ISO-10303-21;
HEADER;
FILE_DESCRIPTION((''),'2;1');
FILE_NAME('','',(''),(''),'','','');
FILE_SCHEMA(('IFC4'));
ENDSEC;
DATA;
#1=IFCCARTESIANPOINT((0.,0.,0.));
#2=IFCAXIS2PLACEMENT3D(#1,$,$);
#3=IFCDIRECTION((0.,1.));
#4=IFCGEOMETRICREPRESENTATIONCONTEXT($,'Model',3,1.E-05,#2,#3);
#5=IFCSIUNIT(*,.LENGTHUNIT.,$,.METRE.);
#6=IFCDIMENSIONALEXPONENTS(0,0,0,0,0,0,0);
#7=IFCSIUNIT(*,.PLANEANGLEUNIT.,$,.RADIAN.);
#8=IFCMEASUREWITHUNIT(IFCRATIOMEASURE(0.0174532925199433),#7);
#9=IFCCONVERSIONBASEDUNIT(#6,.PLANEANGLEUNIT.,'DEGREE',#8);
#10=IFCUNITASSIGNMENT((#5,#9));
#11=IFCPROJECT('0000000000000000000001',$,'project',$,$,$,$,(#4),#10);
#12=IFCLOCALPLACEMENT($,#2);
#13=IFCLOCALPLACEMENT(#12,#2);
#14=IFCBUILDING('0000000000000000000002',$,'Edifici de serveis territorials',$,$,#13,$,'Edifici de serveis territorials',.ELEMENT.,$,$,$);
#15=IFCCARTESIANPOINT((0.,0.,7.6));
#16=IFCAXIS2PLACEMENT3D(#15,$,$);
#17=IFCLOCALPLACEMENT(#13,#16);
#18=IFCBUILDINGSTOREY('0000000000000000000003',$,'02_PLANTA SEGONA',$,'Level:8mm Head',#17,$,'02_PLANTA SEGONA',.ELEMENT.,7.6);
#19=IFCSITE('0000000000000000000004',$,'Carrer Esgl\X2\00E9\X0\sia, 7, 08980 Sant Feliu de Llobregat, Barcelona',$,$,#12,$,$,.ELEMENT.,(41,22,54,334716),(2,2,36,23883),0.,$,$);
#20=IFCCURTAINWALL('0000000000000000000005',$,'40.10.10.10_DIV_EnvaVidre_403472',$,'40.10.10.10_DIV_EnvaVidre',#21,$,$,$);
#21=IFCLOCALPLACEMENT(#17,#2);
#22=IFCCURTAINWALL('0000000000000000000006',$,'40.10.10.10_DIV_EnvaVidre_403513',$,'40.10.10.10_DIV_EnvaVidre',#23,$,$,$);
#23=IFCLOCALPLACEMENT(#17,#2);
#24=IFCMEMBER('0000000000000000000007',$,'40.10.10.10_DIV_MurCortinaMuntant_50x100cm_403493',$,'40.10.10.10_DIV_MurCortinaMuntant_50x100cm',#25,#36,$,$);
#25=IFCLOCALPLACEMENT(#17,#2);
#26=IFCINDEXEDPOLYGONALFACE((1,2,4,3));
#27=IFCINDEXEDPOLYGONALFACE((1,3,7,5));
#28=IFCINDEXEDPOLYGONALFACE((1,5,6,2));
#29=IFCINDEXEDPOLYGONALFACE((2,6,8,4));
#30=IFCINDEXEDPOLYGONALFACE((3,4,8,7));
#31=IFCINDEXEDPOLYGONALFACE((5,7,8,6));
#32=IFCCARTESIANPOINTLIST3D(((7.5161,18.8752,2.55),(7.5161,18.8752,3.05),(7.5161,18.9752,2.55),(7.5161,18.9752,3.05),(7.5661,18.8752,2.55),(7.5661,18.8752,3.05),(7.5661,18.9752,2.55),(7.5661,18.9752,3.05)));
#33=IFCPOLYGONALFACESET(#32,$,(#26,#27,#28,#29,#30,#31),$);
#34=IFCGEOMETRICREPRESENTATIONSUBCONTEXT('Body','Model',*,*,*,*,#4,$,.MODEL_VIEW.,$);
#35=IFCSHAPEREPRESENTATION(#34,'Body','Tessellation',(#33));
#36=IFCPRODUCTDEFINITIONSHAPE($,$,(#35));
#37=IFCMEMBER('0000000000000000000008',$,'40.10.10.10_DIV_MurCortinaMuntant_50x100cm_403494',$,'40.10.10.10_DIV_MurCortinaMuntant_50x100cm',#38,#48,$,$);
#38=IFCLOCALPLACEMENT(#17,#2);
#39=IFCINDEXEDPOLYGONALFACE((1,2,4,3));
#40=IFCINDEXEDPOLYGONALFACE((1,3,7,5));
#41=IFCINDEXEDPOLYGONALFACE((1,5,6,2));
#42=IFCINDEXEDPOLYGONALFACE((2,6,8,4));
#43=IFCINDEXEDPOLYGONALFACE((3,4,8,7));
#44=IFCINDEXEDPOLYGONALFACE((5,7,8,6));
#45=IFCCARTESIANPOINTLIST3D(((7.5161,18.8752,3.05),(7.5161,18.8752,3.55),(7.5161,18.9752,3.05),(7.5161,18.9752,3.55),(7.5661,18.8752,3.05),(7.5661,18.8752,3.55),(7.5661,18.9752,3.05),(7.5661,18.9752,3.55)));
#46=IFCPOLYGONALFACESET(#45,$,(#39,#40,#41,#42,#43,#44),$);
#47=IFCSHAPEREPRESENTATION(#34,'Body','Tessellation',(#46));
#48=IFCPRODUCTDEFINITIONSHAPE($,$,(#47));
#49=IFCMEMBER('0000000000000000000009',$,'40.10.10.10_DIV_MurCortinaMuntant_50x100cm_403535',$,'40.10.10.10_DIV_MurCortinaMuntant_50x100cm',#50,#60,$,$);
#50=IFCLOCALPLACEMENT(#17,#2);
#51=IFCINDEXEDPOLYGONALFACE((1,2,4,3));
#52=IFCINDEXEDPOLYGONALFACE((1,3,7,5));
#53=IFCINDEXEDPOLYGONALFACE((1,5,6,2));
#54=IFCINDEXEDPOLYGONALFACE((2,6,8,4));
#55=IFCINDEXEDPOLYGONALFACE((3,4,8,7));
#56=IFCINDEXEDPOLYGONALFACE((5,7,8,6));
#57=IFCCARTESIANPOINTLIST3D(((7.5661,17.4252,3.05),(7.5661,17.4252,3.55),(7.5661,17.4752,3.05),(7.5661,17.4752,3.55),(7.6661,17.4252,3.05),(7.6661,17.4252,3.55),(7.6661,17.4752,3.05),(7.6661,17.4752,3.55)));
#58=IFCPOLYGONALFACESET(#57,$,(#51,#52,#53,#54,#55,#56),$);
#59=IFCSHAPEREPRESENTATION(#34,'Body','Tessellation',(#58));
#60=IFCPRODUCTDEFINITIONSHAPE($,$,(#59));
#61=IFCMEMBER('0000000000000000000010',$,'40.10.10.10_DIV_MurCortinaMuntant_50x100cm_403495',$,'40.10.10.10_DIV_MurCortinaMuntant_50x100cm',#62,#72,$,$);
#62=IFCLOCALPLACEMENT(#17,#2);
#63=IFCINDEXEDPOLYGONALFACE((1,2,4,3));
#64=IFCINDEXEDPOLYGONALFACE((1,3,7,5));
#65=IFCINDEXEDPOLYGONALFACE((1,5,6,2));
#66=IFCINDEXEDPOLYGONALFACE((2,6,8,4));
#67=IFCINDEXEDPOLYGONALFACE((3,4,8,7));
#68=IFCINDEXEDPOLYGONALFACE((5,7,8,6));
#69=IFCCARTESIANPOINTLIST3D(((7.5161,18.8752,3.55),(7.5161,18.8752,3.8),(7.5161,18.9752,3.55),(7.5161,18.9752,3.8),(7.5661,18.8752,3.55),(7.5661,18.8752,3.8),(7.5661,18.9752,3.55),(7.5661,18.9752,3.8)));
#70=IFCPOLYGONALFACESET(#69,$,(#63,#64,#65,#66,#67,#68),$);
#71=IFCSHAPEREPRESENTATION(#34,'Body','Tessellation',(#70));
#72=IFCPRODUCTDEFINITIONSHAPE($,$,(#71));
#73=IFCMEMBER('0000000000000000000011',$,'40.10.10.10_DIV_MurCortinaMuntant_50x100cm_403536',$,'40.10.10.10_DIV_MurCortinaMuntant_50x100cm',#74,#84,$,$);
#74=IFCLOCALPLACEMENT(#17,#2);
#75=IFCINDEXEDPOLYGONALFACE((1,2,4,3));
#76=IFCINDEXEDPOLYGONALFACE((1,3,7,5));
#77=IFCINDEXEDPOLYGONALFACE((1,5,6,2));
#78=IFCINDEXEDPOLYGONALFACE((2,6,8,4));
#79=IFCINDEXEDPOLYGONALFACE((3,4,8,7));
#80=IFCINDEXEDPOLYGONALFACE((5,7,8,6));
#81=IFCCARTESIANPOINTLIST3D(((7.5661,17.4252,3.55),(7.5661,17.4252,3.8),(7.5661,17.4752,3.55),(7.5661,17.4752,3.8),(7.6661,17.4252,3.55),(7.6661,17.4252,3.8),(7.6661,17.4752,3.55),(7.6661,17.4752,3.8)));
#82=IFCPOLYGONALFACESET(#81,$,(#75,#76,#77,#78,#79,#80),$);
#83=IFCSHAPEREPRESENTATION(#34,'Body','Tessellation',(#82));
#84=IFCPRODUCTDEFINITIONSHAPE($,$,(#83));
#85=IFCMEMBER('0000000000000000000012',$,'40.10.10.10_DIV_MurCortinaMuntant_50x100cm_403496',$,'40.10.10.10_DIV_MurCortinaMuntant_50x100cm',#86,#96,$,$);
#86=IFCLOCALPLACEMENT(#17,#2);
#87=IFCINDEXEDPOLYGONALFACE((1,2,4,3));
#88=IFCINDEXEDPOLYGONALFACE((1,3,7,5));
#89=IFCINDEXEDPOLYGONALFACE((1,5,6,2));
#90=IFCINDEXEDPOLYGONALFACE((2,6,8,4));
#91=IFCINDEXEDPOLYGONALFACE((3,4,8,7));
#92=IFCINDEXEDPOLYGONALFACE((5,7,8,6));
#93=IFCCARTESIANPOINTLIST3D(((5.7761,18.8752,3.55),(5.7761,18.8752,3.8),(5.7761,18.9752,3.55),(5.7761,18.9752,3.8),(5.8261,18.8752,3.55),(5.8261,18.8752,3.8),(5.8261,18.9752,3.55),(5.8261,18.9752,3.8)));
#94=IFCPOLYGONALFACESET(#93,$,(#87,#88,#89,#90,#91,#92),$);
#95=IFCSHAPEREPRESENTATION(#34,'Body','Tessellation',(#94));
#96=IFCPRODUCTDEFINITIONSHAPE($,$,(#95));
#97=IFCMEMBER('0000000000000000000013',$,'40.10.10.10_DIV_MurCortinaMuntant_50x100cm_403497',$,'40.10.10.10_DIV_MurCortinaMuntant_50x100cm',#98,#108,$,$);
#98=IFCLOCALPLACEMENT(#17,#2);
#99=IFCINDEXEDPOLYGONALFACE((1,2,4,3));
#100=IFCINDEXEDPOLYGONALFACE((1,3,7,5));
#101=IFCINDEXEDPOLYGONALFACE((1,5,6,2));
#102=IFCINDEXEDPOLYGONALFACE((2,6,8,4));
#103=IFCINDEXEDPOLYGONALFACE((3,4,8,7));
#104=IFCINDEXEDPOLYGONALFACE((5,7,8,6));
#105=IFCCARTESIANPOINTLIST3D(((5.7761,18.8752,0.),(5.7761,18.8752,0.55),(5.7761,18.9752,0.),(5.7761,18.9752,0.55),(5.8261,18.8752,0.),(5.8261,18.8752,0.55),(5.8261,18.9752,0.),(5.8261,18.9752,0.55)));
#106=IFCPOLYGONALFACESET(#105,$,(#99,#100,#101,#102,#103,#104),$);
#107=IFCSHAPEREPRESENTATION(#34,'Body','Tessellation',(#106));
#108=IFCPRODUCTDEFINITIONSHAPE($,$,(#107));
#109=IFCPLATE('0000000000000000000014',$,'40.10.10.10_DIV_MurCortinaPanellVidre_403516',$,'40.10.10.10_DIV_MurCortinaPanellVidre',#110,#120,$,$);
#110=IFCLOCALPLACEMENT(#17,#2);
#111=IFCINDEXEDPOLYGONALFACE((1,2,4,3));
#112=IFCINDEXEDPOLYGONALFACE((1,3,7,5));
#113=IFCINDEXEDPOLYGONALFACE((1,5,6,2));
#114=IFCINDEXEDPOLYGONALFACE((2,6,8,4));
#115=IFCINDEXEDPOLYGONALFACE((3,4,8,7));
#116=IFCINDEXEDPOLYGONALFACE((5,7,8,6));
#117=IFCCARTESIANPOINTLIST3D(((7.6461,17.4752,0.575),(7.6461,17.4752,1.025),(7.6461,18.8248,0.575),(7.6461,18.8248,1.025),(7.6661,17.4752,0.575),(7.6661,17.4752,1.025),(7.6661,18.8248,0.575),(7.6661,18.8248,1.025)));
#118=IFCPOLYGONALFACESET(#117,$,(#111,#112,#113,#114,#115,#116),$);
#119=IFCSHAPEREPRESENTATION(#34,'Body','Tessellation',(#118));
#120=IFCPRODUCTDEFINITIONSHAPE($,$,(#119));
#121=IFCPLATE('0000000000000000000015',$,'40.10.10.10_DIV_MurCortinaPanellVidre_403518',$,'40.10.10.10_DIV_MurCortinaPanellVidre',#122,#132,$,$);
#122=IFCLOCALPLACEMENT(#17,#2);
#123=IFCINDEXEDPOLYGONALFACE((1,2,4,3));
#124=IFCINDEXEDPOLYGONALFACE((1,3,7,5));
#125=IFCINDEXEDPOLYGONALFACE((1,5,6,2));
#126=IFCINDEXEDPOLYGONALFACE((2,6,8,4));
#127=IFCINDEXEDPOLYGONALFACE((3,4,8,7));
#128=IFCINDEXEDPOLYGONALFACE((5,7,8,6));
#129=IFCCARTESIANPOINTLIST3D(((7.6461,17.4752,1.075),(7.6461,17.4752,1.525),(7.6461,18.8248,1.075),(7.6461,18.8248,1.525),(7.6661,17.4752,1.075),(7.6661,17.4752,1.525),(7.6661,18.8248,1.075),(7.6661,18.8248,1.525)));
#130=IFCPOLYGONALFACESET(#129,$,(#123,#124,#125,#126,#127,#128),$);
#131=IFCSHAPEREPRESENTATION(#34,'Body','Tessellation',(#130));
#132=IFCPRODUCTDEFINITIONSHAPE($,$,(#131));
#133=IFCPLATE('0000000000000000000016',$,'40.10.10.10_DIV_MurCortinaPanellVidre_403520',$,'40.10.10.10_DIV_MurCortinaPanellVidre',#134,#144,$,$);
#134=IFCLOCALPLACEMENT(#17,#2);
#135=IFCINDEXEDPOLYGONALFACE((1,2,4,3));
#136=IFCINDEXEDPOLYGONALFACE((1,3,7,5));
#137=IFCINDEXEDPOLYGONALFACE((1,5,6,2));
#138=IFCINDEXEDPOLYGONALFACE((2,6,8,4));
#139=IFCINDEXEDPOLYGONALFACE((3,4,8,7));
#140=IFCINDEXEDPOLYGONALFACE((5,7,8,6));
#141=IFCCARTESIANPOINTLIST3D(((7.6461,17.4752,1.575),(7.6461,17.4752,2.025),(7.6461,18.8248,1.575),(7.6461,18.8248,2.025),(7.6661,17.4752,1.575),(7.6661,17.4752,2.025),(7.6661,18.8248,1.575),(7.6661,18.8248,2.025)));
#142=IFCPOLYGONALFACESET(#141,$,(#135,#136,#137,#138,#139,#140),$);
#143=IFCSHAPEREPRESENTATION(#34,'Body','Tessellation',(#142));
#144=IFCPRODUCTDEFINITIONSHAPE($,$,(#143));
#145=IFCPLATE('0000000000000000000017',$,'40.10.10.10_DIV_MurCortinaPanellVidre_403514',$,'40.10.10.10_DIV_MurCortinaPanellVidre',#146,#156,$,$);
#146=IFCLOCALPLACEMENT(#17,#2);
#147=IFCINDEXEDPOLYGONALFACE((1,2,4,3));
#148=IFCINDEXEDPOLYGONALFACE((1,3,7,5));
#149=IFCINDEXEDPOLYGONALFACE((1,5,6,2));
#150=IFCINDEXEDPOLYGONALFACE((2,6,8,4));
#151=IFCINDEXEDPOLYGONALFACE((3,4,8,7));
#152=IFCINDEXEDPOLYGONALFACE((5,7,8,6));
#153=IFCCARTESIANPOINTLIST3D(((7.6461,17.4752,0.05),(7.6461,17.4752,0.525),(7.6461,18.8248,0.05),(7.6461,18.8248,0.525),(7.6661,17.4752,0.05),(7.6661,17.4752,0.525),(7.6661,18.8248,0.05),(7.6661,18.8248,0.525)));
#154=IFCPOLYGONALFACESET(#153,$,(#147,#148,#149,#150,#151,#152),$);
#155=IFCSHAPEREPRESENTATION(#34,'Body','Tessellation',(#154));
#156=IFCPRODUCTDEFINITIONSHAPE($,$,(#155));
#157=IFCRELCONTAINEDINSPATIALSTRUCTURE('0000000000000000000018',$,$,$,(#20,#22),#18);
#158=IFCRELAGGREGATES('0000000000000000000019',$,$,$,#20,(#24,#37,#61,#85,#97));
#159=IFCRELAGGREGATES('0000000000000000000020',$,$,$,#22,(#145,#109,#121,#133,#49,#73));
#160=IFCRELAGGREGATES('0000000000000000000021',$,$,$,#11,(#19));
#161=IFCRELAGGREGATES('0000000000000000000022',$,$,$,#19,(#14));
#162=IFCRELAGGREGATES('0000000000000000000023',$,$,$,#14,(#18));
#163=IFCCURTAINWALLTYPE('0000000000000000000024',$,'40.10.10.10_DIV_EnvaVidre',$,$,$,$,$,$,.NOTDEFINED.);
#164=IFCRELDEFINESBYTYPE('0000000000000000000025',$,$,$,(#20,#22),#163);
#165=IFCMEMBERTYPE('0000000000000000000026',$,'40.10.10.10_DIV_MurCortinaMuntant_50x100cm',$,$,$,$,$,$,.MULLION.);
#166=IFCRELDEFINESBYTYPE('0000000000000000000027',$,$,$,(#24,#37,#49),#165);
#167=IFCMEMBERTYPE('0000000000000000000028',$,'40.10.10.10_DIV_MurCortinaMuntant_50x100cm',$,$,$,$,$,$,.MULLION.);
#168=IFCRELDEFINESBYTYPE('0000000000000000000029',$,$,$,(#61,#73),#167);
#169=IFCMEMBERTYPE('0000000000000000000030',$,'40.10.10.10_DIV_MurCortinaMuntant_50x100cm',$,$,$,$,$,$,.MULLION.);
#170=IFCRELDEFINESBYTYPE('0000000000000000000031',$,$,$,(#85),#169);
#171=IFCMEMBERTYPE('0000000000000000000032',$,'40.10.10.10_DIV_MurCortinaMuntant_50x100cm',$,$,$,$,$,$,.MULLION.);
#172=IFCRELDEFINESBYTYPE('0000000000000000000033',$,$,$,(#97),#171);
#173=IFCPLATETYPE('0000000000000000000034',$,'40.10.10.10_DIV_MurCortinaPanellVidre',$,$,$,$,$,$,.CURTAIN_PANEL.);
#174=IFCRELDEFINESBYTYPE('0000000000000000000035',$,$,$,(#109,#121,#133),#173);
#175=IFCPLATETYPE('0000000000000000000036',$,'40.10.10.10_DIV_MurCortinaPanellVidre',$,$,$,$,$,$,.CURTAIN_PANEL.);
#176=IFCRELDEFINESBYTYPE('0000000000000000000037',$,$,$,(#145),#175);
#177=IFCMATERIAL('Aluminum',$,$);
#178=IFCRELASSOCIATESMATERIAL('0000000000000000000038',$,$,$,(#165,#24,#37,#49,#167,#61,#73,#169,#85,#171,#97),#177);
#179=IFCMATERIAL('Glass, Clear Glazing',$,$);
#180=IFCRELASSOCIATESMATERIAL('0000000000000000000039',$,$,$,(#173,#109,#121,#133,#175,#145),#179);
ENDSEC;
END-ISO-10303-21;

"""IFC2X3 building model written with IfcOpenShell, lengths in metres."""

from ifc_helpers import new_model, entity, si_unit, converted_unit, direction, frame, frame_2d, origin, origin_2d_with_axis, place, context, subcontext, project, spatial, rectangle, extrude, source, transform, mapped, material, type_object, type_shapes, element, aggregate, save


model = new_model("IFC2X3")

# Units and contexts
model_context = context("Model", 3, precision=1e-05, world=origin(), true_north=direction((0.0, 1.0)))
body_context = subcontext(model_context, "Body", "Model", "MODEL_VIEW")
ifc_project = project(units=[si_unit("LENGTHUNIT", "METRE"), converted_unit("PLANEANGLEUNIT", "DEGREE", entity("IfcRatioMeasure", 0.0174532925199433), si_unit("PLANEANGLEUNIT", "RADIAN"), dimensions=[0, 0, 0, 0, 0, 0, 0])], contexts=[model_context])

# Site, building, storey
site_placement = place(None, origin())
site = spatial("IfcSite", under=ifc_project, at=site_placement, Name="Carrer Església, 7, 08980 Sant Feliu de Llobregat, Barcelona", CompositionType="ELEMENT", RefLatitude=(41, 22, 54, 334716), RefLongitude=(2, 2, 36, 23883), RefElevation=0.0)
building_placement = place(site_placement, origin())
building = spatial("IfcBuilding", under=site, at=building_placement, Name="Edifici de serveis territorials", LongName="Edifici de serveis territorials", CompositionType="ELEMENT")
storey_placement = place(building_placement, frame((0.0, 0.0, 7.6)))
storey = spatial("IfcBuildingStorey", under=building, at=storey_placement, Name="02_PLANTA SEGONA", ObjectType="Level:8mm Head", LongName="02_PLANTA SEGONA", CompositionType="ELEMENT", Elevation=7.6)

# Curtain walls
curtain_wall_type = type_object("IfcCurtainWallType", Name="40.10.10.10_DIV_EnvaVidre", PredefinedType="NOTDEFINED")
curtain_wall_1_placement = place(storey_placement, frame((0.0, 0.0, -7.6)))
curtain_wall_1 = element("IfcCurtainWall", 1, at=curtain_wall_1_placement, inside=storey, type_object=curtain_wall_type, Name="40.10.10.10_DIV_EnvaVidre_403472", ObjectType="40.10.10.10_DIV_EnvaVidre")
ifc_material_1 = material(Name="Aluminum")
curtain_wall_2_placement = place(storey_placement, frame((0.0, 0.0, -7.6)))
curtain_wall_2 = element("IfcCurtainWall", 2, at=curtain_wall_2_placement, inside=storey, type_object=curtain_wall_type, Name="40.10.10.10_DIV_EnvaVidre_403513", ObjectType="40.10.10.10_DIV_EnvaVidre")

# Members
member_type_1 = type_object("IfcMemberType", Name="40.10.10.10_DIV_MurCortinaMuntant_50x100cm", PredefinedType="MULLION", material=ifc_material_1)
shared_shape_1 = source(origin(), body_context, "Body", "SweptSolid", [
    extrude(rectangle(XDim=0.1, YDim=0.05, at=origin_2d_with_axis()), frame((-0.025, 0.0, -0.5), z_axis=(0.0, 0.0, 1.0), x_axis=(0.0, -1.0, 0.0)), (0.0, 0.0, 1.0), 0.5),
])
type_shapes(member_type_1, [shared_shape_1])
member_1_placement = place(storey_placement, frame((7.5661, 18.9252, 2.55), z_axis=(0.0, 0.0, -1.0), x_axis=(1.0, 0.0, 0.0)))
member_1 = element("IfcMember", 3, at=member_1_placement, type_object=member_type_1, material=ifc_material_1, Name="40.10.10.10_DIV_MurCortinaMuntant_50x100cm_403493", ObjectType="40.10.10.10_DIV_MurCortinaMuntant_50x100cm", context=body_context, shape_type="MappedRepresentation", body=[
    mapped(shared_shape_1, transform((0.0, 0.0, 0.0), scale=1.0)),
])
member_2_placement = place(storey_placement, frame((7.5661, 18.9252, 3.05), z_axis=(0.0, 0.0, -1.0), x_axis=(1.0, 0.0, 0.0)))
member_2 = element("IfcMember", 4, at=member_2_placement, type_object=member_type_1, material=ifc_material_1, Name="40.10.10.10_DIV_MurCortinaMuntant_50x100cm_403494", ObjectType="40.10.10.10_DIV_MurCortinaMuntant_50x100cm", context=body_context, shape_type="MappedRepresentation", body=[
    mapped(shared_shape_1, transform((0.0, 0.0, 0.0), scale=1.0)),
])
member_3_placement = place(storey_placement, frame((7.6161, 17.4252, 3.05), z_axis=(0.0, 0.0, -1.0), x_axis=(0.0, -1.0, 0.0)))
member_3 = element("IfcMember", 5, at=member_3_placement, type_object=member_type_1, material=ifc_material_1, Name="40.10.10.10_DIV_MurCortinaMuntant_50x100cm_403535", ObjectType="40.10.10.10_DIV_MurCortinaMuntant_50x100cm", context=body_context, shape_type="MappedRepresentation", body=[
    mapped(shared_shape_1, transform((0.0, 0.0, 0.0), scale=1.0)),
])
member_type_2 = type_object("IfcMemberType", Name="40.10.10.10_DIV_MurCortinaMuntant_50x100cm", PredefinedType="MULLION", material=ifc_material_1)
shared_shape_2 = source(origin(), body_context, "Body", "SweptSolid", [
    extrude(rectangle(XDim=0.1, YDim=0.05, at=origin_2d_with_axis()), frame((-0.025, 0.0, -0.25), z_axis=(0.0, 0.0, 1.0), x_axis=(0.0, -1.0, 0.0)), (0.0, 0.0, 1.0), 0.25),
])
type_shapes(member_type_2, [shared_shape_2])
member_4_placement = place(storey_placement, frame((7.5661, 18.9252, 3.55), z_axis=(0.0, 0.0, -1.0), x_axis=(1.0, 0.0, 0.0)))
member_4 = element("IfcMember", 6, at=member_4_placement, type_object=member_type_2, material=ifc_material_1, Name="40.10.10.10_DIV_MurCortinaMuntant_50x100cm_403495", ObjectType="40.10.10.10_DIV_MurCortinaMuntant_50x100cm", context=body_context, shape_type="MappedRepresentation", body=[
    mapped(shared_shape_2, transform((0.0, 0.0, 0.0), scale=1.0)),
])
member_5_placement = place(storey_placement, frame((7.6161, 17.4252, 3.55), z_axis=(0.0, 0.0, -1.0), x_axis=(0.0, -1.0, 0.0)))
member_5 = element("IfcMember", 7, at=member_5_placement, type_object=member_type_2, material=ifc_material_1, Name="40.10.10.10_DIV_MurCortinaMuntant_50x100cm_403536", ObjectType="40.10.10.10_DIV_MurCortinaMuntant_50x100cm", context=body_context, shape_type="MappedRepresentation", body=[
    mapped(shared_shape_2, transform((0.0, 0.0, 0.0), scale=1.0)),
])
member_type_3 = type_object("IfcMemberType", Name="40.10.10.10_DIV_MurCortinaMuntant_50x100cm", PredefinedType="MULLION", material=ifc_material_1)
shared_shape_3 = source(origin(), body_context, "Body", "SweptSolid", [
    extrude(rectangle(XDim=0.1, YDim=0.05, at=origin_2d_with_axis()), frame((-0.025, 0.0, -0.25), z_axis=(0.0, 0.0, 1.0), x_axis=(0.0, -1.0, 0.0)), (0.0, 0.0, 1.0), 0.25),
])
type_shapes(member_type_3, [shared_shape_3])
member_6_placement = place(storey_placement, frame((5.7761, 18.9252, 3.8), z_axis=(0.0, 0.0, 1.0), x_axis=(-1.0, 0.0, 0.0)))
member_6 = element("IfcMember", 8, at=member_6_placement, type_object=member_type_3, material=ifc_material_1, Name="40.10.10.10_DIV_MurCortinaMuntant_50x100cm_403496", ObjectType="40.10.10.10_DIV_MurCortinaMuntant_50x100cm", context=body_context, shape_type="MappedRepresentation", body=[
    mapped(shared_shape_3, transform((0.0, 0.0, 0.0), scale=1.0)),
])
member_type_4 = type_object("IfcMemberType", Name="40.10.10.10_DIV_MurCortinaMuntant_50x100cm", PredefinedType="MULLION", material=ifc_material_1)
shared_shape_4 = source(origin(), body_context, "Body", "SweptSolid", [
    extrude(rectangle(XDim=0.1, YDim=0.05, at=origin_2d_with_axis()), frame((-0.025, 0.0, -0.55), z_axis=(0.0, 0.0, 1.0), x_axis=(0.0, -1.0, 0.0)), (0.0, 0.0, 1.0), 0.55),
])
type_shapes(member_type_4, [shared_shape_4])
member_7_placement = place(storey_placement, frame((5.7761, 18.9252, 0.55), z_axis=(0.0, 0.0, 1.0), x_axis=(-1.0, 0.0, 0.0)))
member_7 = element("IfcMember", 9, at=member_7_placement, type_object=member_type_4, material=ifc_material_1, Name="40.10.10.10_DIV_MurCortinaMuntant_50x100cm_403497", ObjectType="40.10.10.10_DIV_MurCortinaMuntant_50x100cm", context=body_context, shape_type="MappedRepresentation", body=[
    mapped(shared_shape_4, transform((0.0, 0.0, 0.0), scale=1.0)),
])

# Plates
ifc_material_2 = material(Name="Glass, Clear Glazing")
plate_type_1 = type_object("IfcPlateType", Name="40.10.10.10_DIV_MurCortinaPanellVidre", PredefinedType="CURTAIN_PANEL", material=ifc_material_2)
shared_shape_5 = source(origin(), body_context, "Body", "SweptSolid", [
    extrude(rectangle(XDim=0.02, YDim=1.3496, at=frame_2d((0.0, 0.0), x_axis=(1.0, 0.0))), frame((0.6748, 0.01, 0.0), z_axis=(0.0, 0.0, 1.0), x_axis=(0.0, 1.0, 0.0)), (0.0, 0.0, 1.0), 0.45),
])
type_shapes(plate_type_1, [shared_shape_5])
plate_1_placement = place(curtain_wall_2_placement, frame((7.6461, 18.8248, 8.175), z_axis=(0.0, 0.0, 1.0), x_axis=(0.0, -1.0, 0.0)))
plate_1 = element("IfcPlate", 10, at=plate_1_placement, type_object=plate_type_1, material=ifc_material_2, Name="40.10.10.10_DIV_MurCortinaPanellVidre_403516", ObjectType="40.10.10.10_DIV_MurCortinaPanellVidre", context=body_context, shape_type="MappedRepresentation", body=[
    mapped(shared_shape_5, transform((0.0, 0.0, 0.0), scale=1.0)),
])
plate_2_placement = place(curtain_wall_2_placement, frame((7.6461, 18.8248, 8.675), z_axis=(0.0, 0.0, 1.0), x_axis=(0.0, -1.0, 0.0)))
plate_2 = element("IfcPlate", 11, at=plate_2_placement, type_object=plate_type_1, material=ifc_material_2, Name="40.10.10.10_DIV_MurCortinaPanellVidre_403518", ObjectType="40.10.10.10_DIV_MurCortinaPanellVidre", context=body_context, shape_type="MappedRepresentation", body=[
    mapped(shared_shape_5, transform((0.0, 0.0, 0.0), scale=1.0)),
])
plate_3_placement = place(curtain_wall_2_placement, frame((7.6461, 18.8248, 9.175), z_axis=(0.0, 0.0, 1.0), x_axis=(0.0, -1.0, 0.0)))
plate_3 = element("IfcPlate", 12, at=plate_3_placement, type_object=plate_type_1, material=ifc_material_2, Name="40.10.10.10_DIV_MurCortinaPanellVidre_403520", ObjectType="40.10.10.10_DIV_MurCortinaPanellVidre", context=body_context, shape_type="MappedRepresentation", body=[
    mapped(shared_shape_5, transform((0.0, 0.0, 0.0), scale=1.0)),
])
aggregate(curtain_wall_1, [member_1, member_2, member_4, member_6, member_7])
plate_type_2 = type_object("IfcPlateType", Name="40.10.10.10_DIV_MurCortinaPanellVidre", PredefinedType="CURTAIN_PANEL", material=ifc_material_2)
shared_shape_6 = source(origin(), body_context, "Body", "SweptSolid", [
    extrude(rectangle(XDim=0.02, YDim=1.3496, at=frame_2d((0.0, 0.0), x_axis=(1.0, 0.0))), frame((0.6748, 0.01, 0.0), z_axis=(0.0, 0.0, 1.0), x_axis=(0.0, 1.0, 0.0)), (0.0, 0.0, 1.0), 0.475),
])
type_shapes(plate_type_2, [shared_shape_6])
plate_4_placement = place(curtain_wall_2_placement, frame((7.6461, 18.8248, 7.65), z_axis=(0.0, 0.0, 1.0), x_axis=(0.0, -1.0, 0.0)))
plate_4 = element("IfcPlate", 13, at=plate_4_placement, type_object=plate_type_2, material=ifc_material_2, Name="40.10.10.10_DIV_MurCortinaPanellVidre_403514", ObjectType="40.10.10.10_DIV_MurCortinaPanellVidre", context=body_context, shape_type="MappedRepresentation", body=[
    mapped(shared_shape_6, transform((0.0, 0.0, 0.0), scale=1.0)),
])
aggregate(curtain_wall_2, [plate_4, plate_1, plate_2, plate_3, member_3, member_5])

save(model, "model.ifc")
